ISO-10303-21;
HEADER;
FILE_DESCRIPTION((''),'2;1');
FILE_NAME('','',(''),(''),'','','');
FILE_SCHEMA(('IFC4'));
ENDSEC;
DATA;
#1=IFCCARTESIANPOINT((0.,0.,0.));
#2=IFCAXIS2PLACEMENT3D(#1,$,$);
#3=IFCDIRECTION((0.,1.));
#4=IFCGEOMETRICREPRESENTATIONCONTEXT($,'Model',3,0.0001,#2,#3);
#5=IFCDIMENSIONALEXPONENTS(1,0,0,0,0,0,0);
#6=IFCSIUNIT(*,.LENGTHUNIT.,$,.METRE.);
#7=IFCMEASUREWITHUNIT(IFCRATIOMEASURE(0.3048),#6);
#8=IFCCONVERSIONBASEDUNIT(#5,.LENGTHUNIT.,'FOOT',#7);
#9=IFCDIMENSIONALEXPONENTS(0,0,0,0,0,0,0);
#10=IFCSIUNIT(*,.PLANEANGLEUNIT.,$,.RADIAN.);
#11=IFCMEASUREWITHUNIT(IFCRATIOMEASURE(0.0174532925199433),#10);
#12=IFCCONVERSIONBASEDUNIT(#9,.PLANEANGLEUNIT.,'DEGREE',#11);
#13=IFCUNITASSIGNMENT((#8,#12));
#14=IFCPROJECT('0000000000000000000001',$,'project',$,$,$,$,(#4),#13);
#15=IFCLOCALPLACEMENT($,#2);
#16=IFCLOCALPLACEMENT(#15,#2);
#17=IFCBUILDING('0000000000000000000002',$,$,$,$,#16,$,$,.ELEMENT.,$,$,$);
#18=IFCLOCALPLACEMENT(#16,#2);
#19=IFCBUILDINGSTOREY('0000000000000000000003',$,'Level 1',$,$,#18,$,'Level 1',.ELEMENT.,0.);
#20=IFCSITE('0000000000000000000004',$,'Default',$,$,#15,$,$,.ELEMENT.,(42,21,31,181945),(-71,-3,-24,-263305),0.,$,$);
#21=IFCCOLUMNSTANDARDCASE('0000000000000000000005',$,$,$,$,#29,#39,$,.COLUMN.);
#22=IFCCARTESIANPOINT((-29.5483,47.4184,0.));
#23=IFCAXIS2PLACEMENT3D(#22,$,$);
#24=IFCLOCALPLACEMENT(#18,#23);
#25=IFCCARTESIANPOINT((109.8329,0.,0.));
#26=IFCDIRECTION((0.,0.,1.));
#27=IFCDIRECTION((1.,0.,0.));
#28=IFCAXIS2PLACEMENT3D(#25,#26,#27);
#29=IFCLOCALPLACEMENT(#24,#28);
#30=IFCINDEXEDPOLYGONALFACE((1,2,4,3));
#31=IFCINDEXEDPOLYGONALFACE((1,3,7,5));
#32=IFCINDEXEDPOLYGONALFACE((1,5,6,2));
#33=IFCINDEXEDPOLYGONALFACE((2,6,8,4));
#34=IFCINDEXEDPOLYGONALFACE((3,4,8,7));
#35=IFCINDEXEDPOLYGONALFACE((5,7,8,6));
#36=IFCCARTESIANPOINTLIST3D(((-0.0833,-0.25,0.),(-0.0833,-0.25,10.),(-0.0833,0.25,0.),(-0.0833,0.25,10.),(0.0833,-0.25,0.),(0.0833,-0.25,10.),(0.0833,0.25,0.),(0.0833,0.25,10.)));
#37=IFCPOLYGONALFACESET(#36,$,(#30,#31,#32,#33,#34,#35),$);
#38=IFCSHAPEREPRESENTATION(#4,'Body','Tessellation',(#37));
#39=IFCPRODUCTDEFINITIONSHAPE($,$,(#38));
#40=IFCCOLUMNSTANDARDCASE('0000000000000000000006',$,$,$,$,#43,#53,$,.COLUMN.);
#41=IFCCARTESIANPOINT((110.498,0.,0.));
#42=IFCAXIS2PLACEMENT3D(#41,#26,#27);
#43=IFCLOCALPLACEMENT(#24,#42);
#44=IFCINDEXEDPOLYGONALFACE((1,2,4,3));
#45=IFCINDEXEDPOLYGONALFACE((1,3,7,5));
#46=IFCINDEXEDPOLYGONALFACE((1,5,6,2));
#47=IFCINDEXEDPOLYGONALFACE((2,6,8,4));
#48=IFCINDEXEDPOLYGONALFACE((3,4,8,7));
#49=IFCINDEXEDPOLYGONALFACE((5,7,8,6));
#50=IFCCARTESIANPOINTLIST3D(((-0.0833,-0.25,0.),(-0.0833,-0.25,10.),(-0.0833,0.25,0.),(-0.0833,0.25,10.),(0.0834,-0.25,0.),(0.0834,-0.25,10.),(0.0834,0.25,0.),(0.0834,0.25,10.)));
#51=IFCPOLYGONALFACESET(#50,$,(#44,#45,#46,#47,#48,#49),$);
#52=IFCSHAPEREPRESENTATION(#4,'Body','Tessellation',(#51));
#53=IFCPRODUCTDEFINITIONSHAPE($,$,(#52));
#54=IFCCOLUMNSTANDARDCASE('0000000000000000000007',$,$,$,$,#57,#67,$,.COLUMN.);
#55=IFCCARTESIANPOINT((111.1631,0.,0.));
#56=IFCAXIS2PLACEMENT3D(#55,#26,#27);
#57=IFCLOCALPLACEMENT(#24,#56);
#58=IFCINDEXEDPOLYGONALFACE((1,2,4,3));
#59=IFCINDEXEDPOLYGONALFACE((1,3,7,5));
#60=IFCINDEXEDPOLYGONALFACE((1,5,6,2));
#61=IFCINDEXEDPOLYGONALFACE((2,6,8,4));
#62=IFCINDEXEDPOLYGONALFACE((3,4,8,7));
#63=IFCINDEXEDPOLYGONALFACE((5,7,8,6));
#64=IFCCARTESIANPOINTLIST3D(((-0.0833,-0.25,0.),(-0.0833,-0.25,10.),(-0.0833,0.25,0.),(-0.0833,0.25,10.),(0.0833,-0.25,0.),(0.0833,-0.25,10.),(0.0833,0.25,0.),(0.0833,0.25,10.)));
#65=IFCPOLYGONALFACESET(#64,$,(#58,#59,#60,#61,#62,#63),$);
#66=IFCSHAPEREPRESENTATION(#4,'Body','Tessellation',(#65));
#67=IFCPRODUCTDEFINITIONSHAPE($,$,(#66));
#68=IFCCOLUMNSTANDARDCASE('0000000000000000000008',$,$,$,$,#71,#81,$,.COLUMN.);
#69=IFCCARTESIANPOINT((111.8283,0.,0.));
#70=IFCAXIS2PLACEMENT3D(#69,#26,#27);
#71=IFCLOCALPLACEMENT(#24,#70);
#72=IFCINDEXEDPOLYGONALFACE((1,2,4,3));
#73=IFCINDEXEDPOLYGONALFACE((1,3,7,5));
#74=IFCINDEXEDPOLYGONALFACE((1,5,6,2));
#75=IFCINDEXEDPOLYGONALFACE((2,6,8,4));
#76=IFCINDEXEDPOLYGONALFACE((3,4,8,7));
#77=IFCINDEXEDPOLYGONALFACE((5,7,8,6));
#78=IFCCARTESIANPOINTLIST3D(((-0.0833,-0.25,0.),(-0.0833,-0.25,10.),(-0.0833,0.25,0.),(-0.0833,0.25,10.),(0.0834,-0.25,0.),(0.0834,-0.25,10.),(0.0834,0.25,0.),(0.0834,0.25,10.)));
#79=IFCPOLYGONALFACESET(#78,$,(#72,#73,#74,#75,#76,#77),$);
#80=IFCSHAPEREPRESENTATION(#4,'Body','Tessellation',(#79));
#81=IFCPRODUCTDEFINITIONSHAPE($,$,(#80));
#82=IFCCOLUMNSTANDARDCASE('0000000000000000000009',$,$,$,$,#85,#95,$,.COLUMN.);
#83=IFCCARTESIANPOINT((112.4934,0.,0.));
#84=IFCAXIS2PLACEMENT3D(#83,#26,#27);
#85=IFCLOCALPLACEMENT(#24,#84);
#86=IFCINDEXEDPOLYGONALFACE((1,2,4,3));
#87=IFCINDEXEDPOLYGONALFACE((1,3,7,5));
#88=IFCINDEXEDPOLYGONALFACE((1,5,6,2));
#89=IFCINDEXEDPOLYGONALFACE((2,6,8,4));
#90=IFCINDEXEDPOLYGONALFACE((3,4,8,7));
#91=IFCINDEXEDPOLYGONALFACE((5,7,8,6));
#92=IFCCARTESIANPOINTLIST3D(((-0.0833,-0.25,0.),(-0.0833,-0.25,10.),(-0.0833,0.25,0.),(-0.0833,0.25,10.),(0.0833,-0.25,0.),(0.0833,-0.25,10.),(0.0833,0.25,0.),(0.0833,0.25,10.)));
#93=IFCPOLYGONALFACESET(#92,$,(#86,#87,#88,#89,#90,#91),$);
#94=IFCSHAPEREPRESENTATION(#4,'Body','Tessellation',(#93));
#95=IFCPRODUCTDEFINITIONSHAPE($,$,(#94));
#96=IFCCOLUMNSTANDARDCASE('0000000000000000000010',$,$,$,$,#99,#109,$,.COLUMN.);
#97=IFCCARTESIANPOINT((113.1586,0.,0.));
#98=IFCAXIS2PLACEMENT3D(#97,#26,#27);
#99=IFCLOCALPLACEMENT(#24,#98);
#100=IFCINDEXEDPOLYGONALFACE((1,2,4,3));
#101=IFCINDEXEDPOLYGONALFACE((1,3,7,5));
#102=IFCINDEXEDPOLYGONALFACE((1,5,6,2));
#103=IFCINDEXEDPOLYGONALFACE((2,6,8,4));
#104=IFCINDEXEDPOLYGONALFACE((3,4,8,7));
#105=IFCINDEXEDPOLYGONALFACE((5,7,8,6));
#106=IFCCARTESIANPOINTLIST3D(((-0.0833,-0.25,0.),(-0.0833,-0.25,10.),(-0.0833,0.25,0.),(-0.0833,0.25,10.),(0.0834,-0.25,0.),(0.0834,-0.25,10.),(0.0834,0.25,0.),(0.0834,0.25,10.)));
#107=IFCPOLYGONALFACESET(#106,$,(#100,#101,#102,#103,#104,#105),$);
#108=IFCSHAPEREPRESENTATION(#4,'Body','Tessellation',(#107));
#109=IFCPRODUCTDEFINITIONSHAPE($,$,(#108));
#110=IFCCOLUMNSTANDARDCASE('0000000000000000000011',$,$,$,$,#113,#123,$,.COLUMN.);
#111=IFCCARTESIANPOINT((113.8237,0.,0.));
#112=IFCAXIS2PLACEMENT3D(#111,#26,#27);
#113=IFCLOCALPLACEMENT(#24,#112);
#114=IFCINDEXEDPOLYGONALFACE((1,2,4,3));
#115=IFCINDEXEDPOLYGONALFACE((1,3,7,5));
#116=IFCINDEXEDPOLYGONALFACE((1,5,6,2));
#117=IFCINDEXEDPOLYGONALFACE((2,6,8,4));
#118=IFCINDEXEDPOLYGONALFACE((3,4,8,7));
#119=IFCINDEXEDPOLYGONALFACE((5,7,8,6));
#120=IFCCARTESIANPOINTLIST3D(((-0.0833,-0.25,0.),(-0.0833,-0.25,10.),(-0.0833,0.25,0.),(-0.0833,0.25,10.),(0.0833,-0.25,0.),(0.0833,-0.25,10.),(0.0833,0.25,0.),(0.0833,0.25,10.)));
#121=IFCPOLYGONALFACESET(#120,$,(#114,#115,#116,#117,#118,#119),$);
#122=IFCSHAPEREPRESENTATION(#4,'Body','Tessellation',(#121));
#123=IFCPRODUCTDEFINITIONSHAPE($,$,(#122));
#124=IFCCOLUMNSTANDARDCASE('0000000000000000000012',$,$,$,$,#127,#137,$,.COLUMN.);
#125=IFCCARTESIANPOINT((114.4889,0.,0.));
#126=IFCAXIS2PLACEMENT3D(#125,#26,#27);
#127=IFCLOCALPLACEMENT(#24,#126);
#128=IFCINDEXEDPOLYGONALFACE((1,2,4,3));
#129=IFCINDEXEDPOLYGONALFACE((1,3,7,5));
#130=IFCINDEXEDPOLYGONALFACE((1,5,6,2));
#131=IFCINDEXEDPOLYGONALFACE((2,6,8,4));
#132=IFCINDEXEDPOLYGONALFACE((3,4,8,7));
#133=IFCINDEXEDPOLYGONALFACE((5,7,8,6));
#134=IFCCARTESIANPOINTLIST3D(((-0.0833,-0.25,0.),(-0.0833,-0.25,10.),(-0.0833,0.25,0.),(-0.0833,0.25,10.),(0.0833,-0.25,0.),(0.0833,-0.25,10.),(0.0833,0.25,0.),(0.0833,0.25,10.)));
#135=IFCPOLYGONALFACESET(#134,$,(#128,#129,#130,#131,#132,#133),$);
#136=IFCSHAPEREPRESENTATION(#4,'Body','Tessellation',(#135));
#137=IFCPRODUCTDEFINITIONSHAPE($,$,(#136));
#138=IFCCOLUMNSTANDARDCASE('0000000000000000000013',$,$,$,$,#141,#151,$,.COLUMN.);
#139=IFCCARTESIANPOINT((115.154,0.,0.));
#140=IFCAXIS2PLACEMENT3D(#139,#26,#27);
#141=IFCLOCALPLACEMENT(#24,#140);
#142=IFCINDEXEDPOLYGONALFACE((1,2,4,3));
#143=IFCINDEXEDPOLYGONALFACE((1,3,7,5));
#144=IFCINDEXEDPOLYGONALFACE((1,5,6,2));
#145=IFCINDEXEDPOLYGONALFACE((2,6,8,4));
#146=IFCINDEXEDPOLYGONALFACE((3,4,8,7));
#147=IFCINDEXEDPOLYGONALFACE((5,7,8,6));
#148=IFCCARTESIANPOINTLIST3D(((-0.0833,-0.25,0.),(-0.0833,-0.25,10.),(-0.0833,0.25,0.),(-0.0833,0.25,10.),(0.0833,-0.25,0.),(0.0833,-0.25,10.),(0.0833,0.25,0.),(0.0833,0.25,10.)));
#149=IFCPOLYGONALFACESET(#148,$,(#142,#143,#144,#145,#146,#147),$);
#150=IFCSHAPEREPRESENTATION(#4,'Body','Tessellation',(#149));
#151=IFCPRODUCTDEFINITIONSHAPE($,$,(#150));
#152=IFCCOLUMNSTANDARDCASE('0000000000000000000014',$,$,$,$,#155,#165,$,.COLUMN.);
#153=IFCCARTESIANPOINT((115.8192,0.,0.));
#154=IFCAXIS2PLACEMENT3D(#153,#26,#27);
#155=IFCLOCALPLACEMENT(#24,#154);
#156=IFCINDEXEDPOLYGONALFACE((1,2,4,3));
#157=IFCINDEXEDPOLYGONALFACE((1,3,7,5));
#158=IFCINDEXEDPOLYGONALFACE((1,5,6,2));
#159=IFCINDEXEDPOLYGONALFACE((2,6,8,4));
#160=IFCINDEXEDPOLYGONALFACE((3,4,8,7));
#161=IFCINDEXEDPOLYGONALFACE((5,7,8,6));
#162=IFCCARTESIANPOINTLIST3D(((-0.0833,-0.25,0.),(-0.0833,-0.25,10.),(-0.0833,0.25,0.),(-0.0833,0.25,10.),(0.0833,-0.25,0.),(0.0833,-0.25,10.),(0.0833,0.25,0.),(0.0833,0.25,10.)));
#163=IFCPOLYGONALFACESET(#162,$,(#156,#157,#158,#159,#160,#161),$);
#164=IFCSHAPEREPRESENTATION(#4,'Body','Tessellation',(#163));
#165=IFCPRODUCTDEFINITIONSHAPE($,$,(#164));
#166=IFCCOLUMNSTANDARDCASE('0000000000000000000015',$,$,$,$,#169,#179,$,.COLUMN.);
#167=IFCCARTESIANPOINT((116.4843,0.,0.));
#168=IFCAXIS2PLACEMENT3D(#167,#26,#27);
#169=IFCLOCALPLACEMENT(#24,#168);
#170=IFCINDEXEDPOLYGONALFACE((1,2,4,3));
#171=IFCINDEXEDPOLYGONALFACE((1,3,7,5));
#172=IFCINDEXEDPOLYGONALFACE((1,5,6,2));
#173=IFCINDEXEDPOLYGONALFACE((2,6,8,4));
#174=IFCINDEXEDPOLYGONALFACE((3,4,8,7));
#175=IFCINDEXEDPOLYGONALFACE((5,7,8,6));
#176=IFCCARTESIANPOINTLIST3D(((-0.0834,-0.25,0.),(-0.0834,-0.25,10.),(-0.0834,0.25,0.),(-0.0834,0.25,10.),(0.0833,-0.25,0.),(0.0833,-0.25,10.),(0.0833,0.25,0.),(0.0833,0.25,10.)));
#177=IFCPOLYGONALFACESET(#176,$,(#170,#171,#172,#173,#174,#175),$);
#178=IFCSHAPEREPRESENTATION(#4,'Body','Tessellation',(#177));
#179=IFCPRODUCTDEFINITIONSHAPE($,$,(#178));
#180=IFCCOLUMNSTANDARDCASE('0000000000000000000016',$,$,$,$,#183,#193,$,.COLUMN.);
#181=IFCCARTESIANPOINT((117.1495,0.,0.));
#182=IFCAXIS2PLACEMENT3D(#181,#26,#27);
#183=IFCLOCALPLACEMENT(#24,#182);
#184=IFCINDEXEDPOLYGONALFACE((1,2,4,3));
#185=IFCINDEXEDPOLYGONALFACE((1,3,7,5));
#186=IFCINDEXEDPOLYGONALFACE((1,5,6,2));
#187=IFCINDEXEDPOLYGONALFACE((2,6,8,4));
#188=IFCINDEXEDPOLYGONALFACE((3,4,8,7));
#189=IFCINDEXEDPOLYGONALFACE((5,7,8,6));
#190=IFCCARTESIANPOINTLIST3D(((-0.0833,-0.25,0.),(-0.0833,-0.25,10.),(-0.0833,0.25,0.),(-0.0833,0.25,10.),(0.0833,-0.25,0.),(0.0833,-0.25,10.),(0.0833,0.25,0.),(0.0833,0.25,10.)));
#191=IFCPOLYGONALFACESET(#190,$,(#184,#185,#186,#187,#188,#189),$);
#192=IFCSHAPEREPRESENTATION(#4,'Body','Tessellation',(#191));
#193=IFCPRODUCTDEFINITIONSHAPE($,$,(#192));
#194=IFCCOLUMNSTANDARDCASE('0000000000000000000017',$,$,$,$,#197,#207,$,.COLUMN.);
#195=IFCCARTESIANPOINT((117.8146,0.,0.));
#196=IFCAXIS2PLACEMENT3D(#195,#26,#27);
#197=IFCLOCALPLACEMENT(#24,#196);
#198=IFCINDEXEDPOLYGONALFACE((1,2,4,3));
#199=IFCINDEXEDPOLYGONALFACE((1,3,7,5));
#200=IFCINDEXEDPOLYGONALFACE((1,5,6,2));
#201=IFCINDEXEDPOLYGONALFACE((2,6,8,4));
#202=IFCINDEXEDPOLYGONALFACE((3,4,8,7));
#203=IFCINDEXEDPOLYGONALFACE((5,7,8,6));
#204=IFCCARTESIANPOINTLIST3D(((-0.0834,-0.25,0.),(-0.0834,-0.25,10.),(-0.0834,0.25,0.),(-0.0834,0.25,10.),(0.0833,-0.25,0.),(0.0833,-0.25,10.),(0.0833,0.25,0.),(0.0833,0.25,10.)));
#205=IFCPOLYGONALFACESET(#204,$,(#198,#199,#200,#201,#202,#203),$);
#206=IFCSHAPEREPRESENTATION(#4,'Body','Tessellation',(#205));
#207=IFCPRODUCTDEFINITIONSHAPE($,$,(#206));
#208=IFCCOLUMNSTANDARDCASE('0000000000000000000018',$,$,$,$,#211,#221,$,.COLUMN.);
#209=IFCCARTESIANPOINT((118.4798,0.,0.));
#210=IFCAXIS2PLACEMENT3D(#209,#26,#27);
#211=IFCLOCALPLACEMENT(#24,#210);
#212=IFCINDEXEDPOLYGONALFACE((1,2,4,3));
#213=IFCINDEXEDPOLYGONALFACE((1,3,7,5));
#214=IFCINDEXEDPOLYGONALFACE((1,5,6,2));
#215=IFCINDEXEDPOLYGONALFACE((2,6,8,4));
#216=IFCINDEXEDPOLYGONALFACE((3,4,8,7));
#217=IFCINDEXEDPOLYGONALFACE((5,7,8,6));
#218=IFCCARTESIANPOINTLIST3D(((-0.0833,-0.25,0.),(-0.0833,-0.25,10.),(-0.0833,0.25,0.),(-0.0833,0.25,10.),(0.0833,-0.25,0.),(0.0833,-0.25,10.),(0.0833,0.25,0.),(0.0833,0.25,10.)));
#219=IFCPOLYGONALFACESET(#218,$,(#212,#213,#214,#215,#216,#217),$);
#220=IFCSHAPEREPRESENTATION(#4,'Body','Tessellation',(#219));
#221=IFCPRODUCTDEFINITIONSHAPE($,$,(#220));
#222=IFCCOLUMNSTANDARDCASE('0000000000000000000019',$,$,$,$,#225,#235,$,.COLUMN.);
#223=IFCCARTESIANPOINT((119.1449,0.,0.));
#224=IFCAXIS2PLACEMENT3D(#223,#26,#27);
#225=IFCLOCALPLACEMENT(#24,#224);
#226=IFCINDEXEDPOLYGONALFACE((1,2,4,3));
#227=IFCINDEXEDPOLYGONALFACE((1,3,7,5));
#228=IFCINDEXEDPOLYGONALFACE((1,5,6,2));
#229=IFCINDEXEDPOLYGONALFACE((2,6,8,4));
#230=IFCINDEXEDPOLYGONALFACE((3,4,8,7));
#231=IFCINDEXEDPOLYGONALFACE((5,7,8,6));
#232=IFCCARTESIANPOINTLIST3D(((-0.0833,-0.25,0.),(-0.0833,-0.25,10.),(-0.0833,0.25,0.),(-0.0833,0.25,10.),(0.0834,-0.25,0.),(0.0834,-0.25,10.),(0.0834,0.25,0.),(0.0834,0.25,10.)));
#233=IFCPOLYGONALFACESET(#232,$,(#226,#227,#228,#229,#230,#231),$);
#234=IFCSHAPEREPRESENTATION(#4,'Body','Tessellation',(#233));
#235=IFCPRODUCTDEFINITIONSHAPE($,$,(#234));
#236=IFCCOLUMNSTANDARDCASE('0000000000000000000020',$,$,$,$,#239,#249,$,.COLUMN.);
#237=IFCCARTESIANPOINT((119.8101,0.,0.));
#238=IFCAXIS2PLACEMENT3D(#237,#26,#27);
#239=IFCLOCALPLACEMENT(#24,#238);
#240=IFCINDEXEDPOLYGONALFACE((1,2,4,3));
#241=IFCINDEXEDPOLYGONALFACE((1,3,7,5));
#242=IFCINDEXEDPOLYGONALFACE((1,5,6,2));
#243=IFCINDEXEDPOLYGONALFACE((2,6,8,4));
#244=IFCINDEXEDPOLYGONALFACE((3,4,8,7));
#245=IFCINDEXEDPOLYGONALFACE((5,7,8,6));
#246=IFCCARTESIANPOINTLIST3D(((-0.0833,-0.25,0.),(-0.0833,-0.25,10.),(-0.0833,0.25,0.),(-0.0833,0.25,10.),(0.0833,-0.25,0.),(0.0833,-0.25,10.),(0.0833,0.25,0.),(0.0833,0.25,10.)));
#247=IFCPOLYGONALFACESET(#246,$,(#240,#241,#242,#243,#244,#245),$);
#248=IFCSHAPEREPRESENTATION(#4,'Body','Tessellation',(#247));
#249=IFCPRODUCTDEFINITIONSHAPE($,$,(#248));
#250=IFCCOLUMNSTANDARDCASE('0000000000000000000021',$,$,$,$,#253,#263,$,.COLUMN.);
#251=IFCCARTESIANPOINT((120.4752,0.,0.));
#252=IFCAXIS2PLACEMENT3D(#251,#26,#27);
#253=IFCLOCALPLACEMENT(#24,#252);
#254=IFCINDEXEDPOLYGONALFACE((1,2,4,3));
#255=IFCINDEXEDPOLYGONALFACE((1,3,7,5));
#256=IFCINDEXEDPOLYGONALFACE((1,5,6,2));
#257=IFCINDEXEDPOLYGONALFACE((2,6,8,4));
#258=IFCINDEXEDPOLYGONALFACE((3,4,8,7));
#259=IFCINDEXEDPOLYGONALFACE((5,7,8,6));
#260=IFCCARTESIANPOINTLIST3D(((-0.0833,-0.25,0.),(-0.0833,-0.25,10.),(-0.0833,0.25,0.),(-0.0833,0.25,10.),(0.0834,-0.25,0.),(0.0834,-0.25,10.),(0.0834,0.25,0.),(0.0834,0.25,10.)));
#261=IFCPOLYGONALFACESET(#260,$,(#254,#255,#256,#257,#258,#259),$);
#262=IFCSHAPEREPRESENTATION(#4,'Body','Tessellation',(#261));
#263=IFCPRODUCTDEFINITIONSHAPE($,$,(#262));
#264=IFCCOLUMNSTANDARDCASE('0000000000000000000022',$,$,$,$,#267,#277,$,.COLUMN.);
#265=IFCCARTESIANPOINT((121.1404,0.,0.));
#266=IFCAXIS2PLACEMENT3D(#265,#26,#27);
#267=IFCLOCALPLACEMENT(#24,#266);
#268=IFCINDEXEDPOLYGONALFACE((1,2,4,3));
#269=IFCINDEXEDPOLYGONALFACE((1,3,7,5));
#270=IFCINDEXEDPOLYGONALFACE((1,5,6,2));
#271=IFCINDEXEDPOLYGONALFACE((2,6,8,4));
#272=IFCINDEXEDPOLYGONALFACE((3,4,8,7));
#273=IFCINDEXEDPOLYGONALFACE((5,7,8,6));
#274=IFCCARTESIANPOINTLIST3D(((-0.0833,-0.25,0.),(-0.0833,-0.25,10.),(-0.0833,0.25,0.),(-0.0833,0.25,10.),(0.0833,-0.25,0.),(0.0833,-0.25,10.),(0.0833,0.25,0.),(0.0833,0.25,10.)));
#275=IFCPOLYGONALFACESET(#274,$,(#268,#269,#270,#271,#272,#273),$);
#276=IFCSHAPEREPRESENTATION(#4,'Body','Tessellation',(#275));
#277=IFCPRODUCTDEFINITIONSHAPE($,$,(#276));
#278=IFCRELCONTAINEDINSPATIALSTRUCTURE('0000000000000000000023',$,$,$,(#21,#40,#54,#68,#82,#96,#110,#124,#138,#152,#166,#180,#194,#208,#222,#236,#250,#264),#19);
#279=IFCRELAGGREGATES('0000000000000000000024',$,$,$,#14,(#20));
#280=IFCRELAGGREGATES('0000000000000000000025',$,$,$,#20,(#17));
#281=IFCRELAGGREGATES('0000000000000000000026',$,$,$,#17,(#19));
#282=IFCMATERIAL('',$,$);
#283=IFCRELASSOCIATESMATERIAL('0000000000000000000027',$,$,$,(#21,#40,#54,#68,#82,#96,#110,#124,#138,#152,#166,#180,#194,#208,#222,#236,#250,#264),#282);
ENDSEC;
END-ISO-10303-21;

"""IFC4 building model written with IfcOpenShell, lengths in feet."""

from ifc_helpers import new_model, entity, si_unit, converted_unit, direction, frame, origin, place, context, project, spatial, rectangle, extrude, material, element, save


model = new_model("IFC4")

# Units and contexts
model_context = context("Model", 3, precision=0.0001, world=origin(), true_north=direction((0.0, 1.0)))
ifc_project = project(units=[converted_unit("LENGTHUNIT", "FOOT", entity("IfcRatioMeasure", 0.3048), si_unit("LENGTHUNIT", "METRE"), dimensions=[1, 0, 0, 0, 0, 0, 0]), converted_unit("PLANEANGLEUNIT", "DEGREE", entity("IfcRatioMeasure", 0.0174532925199433), si_unit("PLANEANGLEUNIT", "RADIAN"), dimensions=[0, 0, 0, 0, 0, 0, 0])], contexts=[model_context])

# Site, building, storey
site_placement = place(None, origin())
site = spatial("IfcSite", under=ifc_project, at=site_placement, Name="Default", CompositionType="ELEMENT", RefLatitude=(42, 21, 31, 181945), RefLongitude=(-71, -3, -24, -263305), RefElevation=0.0)
building_placement = place(site_placement, origin())
building = spatial("IfcBuilding", under=site, at=building_placement, CompositionType="ELEMENT")
storey_placement = place(building_placement, origin())
storey = spatial("IfcBuildingStorey", under=building, at=storey_placement, Name="Level 1", LongName="Level 1", CompositionType="ELEMENT", Elevation=0.0)

# Columns
ifc_material = material(Name="")
placement = place(storey_placement, frame((-29.5483, 47.4184, 0.0)))
for number, where, z_axis, x_axis in (
    (1, (109.8329, 0.0, 0.0), (0.0, 0.0, 1.0), (1.0, 0.0, 0.0)),
    (2, (110.498, 0.0, 0.0), (0.0, 0.0, 1.0), (1.0, 0.0, 0.0)),
    (3, (111.1631, 0.0, 0.0), (0.0, 0.0, 1.0), (1.0, 0.0, 0.0)),
    (4, (111.8283, 0.0, 0.0), (0.0, 0.0, 1.0), (1.0, 0.0, 0.0)),
    (5, (112.4934, 0.0, 0.0), (0.0, 0.0, 1.0), (1.0, 0.0, 0.0)),
    (6, (113.1586, 0.0, 0.0), (0.0, 0.0, 1.0), (1.0, 0.0, 0.0)),
    (7, (113.8237, 0.0, 0.0), (0.0, 0.0, 1.0), (1.0, 0.0, 0.0)),
    (8, (114.4889, 0.0, 0.0), (0.0, 0.0, 1.0), (1.0, 0.0, 0.0)),
    (9, (115.154, 0.0, 0.0), (0.0, 0.0, 1.0), (1.0, 0.0, 0.0)),
    (10, (115.8192, 0.0, 0.0), (0.0, 0.0, 1.0), (1.0, 0.0, 0.0)),
    (11, (116.4843, 0.0, 0.0), (0.0, 0.0, 1.0), (1.0, 0.0, 0.0)),
    (12, (117.1495, 0.0, 0.0), (0.0, 0.0, 1.0), (1.0, 0.0, 0.0)),
    (13, (117.8146, 0.0, 0.0), (0.0, 0.0, 1.0), (1.0, 0.0, 0.0)),
    (14, (118.4798, 0.0, 0.0), (0.0, 0.0, 1.0), (1.0, 0.0, 0.0)),
    (15, (119.1449, 0.0, 0.0), (0.0, 0.0, 1.0), (1.0, 0.0, 0.0)),
    (16, (119.8101, 0.0, 0.0), (0.0, 0.0, 1.0), (1.0, 0.0, 0.0)),
    (17, (120.4752, 0.0, 0.0), (0.0, 0.0, 1.0), (1.0, 0.0, 0.0)),
    (18, (121.1404, 0.0, 0.0), (0.0, 0.0, 1.0), (1.0, 0.0, 0.0)),
):
    element("IfcColumnStandardCase", number, at=place(placement, frame(where, z_axis=z_axis, x_axis=x_axis)), inside=storey, material=ifc_material, PredefinedType="COLUMN", context=model_context, shape_type="SweptSolid", body=[
        extrude(rectangle(XDim=0.1667, YDim=0.5), origin(), (0.0, 0.0, 1.0), 10.0),
    ])

save(model, "model.ifc")
